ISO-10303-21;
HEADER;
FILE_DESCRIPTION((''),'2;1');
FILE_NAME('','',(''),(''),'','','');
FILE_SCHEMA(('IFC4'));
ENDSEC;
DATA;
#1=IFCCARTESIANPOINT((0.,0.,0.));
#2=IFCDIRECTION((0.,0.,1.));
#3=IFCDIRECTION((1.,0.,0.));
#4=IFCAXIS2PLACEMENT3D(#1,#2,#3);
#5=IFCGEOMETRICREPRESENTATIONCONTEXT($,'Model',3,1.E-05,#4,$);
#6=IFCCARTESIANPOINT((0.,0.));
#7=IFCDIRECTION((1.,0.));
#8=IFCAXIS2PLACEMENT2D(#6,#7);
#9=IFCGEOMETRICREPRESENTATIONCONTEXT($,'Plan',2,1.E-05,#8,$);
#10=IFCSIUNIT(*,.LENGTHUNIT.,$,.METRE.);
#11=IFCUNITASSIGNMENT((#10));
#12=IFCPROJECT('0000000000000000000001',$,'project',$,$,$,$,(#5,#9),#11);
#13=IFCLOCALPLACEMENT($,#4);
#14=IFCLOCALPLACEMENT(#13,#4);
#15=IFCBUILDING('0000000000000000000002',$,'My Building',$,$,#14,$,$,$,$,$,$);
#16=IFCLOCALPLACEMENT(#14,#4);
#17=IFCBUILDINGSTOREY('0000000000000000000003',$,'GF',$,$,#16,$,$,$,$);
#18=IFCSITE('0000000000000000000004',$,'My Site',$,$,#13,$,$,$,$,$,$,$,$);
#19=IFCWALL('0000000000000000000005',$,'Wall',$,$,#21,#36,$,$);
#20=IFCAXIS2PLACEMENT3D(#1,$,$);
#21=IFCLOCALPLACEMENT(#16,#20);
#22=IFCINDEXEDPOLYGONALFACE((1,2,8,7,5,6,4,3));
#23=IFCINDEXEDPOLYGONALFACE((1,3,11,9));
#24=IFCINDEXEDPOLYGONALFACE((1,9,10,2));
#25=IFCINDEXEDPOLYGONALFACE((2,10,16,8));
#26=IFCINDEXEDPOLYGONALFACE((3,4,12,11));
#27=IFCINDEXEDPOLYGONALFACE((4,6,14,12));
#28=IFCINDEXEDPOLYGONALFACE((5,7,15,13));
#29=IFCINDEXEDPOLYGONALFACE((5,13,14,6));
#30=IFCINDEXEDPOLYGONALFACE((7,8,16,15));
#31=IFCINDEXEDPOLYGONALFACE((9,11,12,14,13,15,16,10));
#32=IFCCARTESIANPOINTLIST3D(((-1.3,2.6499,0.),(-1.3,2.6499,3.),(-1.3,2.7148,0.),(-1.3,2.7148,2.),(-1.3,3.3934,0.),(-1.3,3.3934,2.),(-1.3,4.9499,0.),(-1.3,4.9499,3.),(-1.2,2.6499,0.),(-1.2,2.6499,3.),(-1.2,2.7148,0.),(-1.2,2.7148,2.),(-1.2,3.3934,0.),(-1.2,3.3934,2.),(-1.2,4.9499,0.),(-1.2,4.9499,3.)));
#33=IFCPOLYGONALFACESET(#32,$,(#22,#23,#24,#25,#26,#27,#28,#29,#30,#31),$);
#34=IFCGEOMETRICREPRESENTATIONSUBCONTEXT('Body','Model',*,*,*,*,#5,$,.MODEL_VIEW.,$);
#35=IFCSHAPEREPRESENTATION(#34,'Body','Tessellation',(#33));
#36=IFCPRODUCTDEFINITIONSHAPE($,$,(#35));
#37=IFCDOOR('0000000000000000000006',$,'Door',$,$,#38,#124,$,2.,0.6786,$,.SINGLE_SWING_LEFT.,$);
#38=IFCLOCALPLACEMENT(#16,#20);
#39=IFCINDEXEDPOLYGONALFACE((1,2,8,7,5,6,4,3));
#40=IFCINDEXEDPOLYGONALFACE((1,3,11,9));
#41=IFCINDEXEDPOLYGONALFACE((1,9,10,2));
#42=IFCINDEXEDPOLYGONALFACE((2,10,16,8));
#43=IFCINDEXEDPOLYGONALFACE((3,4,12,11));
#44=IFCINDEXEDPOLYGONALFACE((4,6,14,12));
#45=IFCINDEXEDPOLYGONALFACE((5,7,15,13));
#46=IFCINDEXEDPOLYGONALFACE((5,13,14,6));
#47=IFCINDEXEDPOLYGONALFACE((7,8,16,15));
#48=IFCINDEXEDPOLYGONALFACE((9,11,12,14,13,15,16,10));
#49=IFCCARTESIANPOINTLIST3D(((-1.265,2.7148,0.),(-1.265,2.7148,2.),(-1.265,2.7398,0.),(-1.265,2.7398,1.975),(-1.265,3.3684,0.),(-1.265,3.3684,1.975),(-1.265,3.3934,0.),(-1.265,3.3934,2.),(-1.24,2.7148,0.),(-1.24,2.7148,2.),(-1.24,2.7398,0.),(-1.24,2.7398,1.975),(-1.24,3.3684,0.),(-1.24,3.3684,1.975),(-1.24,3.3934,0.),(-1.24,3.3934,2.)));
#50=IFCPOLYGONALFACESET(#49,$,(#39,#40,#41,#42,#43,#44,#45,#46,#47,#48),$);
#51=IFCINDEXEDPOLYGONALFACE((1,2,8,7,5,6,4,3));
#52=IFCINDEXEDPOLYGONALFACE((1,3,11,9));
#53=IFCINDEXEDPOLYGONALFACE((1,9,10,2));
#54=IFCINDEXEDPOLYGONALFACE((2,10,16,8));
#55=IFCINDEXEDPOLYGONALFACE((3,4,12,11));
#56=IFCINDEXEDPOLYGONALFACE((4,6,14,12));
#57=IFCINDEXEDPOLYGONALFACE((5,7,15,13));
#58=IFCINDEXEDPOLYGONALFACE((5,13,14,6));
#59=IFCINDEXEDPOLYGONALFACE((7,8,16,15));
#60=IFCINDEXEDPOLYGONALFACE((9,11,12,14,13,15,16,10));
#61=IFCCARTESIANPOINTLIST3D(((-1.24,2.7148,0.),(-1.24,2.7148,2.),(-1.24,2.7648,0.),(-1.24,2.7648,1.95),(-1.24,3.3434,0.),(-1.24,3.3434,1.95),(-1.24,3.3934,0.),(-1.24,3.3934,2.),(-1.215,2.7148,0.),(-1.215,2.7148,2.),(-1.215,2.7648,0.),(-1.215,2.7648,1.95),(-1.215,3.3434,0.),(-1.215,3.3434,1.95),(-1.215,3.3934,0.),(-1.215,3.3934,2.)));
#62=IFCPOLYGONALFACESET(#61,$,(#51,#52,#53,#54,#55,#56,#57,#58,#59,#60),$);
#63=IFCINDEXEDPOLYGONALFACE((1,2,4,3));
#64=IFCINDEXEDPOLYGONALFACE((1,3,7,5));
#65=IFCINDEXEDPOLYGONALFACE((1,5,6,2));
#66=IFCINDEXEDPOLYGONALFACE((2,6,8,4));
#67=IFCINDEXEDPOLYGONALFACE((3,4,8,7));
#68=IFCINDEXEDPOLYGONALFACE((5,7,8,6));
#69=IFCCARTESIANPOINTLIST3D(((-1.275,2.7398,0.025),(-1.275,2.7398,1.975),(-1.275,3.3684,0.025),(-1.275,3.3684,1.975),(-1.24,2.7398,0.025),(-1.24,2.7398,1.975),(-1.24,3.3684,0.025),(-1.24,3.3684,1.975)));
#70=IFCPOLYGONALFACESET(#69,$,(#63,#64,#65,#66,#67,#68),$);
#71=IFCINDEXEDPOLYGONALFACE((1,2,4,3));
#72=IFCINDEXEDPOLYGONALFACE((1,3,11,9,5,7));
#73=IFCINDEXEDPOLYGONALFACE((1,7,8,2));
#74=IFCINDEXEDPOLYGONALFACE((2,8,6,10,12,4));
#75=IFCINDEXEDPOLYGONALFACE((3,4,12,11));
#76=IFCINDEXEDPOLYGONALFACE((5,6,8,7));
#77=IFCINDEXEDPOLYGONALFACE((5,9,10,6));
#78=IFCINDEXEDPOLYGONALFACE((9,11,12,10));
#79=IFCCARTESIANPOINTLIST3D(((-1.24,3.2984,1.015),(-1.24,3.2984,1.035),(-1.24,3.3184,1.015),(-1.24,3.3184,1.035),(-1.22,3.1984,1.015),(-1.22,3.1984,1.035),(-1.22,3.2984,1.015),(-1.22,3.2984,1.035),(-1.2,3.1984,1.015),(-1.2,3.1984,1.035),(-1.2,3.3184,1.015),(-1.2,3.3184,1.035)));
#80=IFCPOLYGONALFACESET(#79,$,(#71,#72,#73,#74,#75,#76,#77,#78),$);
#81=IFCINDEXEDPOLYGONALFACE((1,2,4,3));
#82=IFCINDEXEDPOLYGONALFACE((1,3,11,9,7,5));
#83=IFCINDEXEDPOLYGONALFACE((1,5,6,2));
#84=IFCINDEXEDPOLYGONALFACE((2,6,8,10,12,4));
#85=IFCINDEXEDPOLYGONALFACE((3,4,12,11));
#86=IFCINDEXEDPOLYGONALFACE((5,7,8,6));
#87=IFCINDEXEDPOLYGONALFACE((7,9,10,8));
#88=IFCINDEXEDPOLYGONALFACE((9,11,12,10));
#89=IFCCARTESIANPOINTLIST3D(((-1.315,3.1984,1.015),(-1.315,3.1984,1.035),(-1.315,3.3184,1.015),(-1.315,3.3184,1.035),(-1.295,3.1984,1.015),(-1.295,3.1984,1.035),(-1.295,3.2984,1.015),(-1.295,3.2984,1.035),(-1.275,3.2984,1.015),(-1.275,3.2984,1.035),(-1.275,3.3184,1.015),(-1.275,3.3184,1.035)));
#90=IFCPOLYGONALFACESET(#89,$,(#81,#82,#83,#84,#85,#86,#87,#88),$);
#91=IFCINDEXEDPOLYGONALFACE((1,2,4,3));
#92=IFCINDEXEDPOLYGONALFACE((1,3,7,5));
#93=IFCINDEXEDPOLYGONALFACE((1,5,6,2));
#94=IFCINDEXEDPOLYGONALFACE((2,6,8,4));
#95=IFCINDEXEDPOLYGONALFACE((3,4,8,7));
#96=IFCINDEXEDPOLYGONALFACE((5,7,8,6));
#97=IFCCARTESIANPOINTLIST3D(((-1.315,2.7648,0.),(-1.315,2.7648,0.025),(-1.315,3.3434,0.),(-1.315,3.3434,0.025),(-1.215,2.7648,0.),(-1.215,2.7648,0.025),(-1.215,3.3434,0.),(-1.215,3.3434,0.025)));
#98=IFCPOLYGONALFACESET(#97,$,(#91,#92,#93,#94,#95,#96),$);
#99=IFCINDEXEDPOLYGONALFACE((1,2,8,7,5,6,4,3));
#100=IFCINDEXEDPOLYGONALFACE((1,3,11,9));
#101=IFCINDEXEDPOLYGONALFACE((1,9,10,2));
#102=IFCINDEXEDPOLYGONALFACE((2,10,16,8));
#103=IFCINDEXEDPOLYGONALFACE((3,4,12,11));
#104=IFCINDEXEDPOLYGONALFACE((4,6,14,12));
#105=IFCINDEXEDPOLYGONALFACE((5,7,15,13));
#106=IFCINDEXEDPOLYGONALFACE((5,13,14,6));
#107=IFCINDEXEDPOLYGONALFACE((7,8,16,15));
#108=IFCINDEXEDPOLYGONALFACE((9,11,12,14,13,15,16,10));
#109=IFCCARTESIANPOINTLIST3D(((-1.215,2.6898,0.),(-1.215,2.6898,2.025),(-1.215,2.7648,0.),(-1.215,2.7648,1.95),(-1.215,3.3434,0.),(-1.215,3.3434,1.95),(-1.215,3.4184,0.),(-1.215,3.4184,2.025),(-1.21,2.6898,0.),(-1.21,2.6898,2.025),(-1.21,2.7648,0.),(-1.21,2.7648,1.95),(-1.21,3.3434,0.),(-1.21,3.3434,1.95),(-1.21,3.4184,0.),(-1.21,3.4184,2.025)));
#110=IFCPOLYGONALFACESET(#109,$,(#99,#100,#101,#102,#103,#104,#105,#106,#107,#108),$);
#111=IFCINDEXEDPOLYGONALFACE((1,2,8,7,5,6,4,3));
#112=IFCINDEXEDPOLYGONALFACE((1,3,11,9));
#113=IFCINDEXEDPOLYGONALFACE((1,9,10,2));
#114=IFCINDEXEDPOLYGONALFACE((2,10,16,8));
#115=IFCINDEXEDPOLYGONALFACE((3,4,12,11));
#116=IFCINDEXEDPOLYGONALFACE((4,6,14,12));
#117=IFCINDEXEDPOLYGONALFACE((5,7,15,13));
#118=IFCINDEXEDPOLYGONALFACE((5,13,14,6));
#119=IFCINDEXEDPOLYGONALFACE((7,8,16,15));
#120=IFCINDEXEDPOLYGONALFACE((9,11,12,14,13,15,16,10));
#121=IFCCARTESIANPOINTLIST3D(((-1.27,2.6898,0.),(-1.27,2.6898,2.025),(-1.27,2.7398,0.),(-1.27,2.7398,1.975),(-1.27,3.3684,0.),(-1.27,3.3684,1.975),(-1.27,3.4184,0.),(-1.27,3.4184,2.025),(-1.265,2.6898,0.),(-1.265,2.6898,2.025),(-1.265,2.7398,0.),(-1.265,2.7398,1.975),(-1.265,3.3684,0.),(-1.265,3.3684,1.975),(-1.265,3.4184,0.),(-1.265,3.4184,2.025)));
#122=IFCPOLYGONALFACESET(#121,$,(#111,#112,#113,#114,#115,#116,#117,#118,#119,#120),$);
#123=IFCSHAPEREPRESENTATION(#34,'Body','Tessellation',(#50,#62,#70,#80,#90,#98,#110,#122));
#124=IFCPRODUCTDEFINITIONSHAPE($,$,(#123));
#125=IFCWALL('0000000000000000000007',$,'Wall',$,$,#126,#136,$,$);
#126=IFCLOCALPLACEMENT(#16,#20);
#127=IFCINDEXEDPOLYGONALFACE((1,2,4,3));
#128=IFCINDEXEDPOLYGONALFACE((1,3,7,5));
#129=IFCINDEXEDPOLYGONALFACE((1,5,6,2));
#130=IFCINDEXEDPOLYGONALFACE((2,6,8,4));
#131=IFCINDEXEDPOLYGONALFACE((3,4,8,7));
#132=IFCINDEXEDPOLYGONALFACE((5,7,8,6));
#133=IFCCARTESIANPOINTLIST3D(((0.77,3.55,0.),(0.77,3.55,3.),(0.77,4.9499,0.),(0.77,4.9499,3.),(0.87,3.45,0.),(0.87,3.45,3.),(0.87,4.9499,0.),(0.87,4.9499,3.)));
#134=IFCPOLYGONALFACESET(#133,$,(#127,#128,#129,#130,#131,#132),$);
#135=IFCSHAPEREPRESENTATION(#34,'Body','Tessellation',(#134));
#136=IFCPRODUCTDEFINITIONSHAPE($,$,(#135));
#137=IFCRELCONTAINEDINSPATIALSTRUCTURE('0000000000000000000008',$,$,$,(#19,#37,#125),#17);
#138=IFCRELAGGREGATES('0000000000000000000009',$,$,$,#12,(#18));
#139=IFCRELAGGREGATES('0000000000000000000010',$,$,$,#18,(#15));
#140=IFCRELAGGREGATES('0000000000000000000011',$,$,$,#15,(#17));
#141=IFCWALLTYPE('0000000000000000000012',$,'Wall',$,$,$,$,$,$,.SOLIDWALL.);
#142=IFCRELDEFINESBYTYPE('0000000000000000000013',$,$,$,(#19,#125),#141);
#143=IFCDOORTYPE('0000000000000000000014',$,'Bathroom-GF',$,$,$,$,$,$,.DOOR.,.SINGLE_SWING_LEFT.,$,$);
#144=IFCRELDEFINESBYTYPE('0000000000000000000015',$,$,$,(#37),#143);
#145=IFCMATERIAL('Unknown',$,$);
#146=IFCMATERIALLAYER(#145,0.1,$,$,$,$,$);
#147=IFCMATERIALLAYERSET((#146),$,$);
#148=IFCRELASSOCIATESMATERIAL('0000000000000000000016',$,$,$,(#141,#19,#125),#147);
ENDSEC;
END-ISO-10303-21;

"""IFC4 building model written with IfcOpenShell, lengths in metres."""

from ifc_helpers import new_model, entity, si_unit, frame, origin_with_axes, origin_2d_with_axis, place, context, subcontext, project, spatial, line, indexed_curve, outline, extrude, shape, source, transform, mapped, material, layer, layer_set, layer_usage, type_object, type_shapes, element, fill, save


model = new_model("IFC4")

# Units and contexts
model_context = context("Model", 3, precision=1e-05, world=origin_with_axes())
plan_context = context("Plan", 2, precision=1e-05, world=origin_2d_with_axis())
body_context_1 = subcontext(model_context, "Body", "Model", "MODEL_VIEW")
body_context_2 = subcontext(plan_context, "Body", "Plan", "PLAN_VIEW")
ifc_project = project(units=[si_unit("LENGTHUNIT", "METRE")], contexts=[model_context, plan_context])

# Site, building, storey
site_placement = place(None, origin_with_axes())
site = spatial("IfcSite", under=ifc_project, at=site_placement, Name="My Site")
building_placement = place(site_placement, origin_with_axes())
building = spatial("IfcBuilding", under=site, at=building_placement, Name="My Building")
storey_placement = place(building_placement, origin_with_axes())
storey = spatial("IfcBuildingStorey", under=building, at=storey_placement, Name="GF")

# Shared definitions
ifc_material = material(Name="Unknown")

# Shared definitions
ifc_layer_1 = layer(ifc_material, 0.1)
ifc_layer_set_1 = layer_set([ifc_layer_1])
wall_type = type_object("IfcWallType", Name="Wall", PredefinedType="SOLIDWALL", material=ifc_layer_set_1)

# Wall, opening, door
ifc_layer_usage_1 = layer_usage(ifc_layer_set_1, "AXIS2", "POSITIVE", 0.0)
wall_1_placement = place(storey_placement, frame((-1.2, 2.6499, 0.0), z_axis=(0.0, 0.0, 1.0), x_axis=(0.0, 1.0, 0.0)))
wall_1 = element("IfcWall", 1, at=wall_1_placement, inside=storey, type_object=wall_type, material=ifc_layer_usage_1, Name="Wall", context=body_context_1, shape_type="SweptSolid", body=[
    extrude(outline(indexed_curve([(0.0, 0.0), (0.0, 0.1), (2.3, 0.1), (2.3, 0.0)], segments=[line(1, 2, 3, 4, 1)])), origin_with_axes(), (0.0, 0.0, 1.0), 3.0),
])
shared_shape_1 = source(origin_with_axes(), body_context_1, "Body", "SweptSolid", [
    extrude(outline(indexed_curve([(0.0, 0.0), (0.6786, 0.0), (0.6786, 2.0), (0.0, 2.0)], segments=[line(1, 2, 3, 4, 1)])), frame((0.0, -0.6, 0.0), z_axis=(0.0, -1.0, 0.0), x_axis=(1.0, 0.0, 0.0)), (0.0, 0.0, -1.0), 1.2),
])
opening_1_placement = place(wall_1_placement, frame((0.0649, 0.015, 0.0), z_axis=(0.0, 0.0, 1.0), x_axis=(1.0, 0.0, 0.0)))
opening_1 = element("IfcOpeningElement", 2, at=opening_1_placement, cuts=wall_1, PredefinedType="OPENING", context=body_context_1, shape_type="MappedRepresentation", body=[
    mapped(shared_shape_1, transform((0.0, 0.0, 0.0), x_axis=(1.0, 0.0, 0.0), y_axis=(0.0, 1.0, 0.0), z_axis=(0.0, 0.0, 1.0), scale=1.0)),
])
door_type_1 = type_object("IfcDoorType", Name="Bathroom-GF", OperationType="SINGLE_SWING_LEFT", PredefinedType="DOOR")
shared_shape_2 = source(origin_with_axes(), body_context_1, "Body", "SweptSolid", [
    extrude(outline(indexed_curve([(0.0, 0.0), (0.0, 2.0), (0.6786, 2.0), (0.6786, 0.0), (0.6536, 0.0), (0.6536, 1.975), (0.025, 1.975), (0.025, 0.0)], segments=[line(1, 2, 3, 4, 5, 6, 7, 8, 1)])), frame((0.0, 0.025, 0.0), z_axis=(0.0, -1.0, 0.0), x_axis=(1.0, 0.0, 0.0)), (0.0, 0.0, -1.0), 0.025),
    extrude(outline(indexed_curve([(0.0, 0.0), (0.0, 2.0), (0.6786, 2.0), (0.6786, 0.0), (0.6286, 0.0), (0.6286, 1.95), (0.05, 1.95), (0.05, 0.0)], segments=[line(1, 2, 3, 4, 5, 6, 7, 8, 1)])), frame((0.0, 0.0, 0.0), z_axis=(0.0, -1.0, 0.0), x_axis=(1.0, 0.0, 0.0)), (0.0, 0.0, -1.0), 0.025),
    extrude(outline(indexed_curve([(0.0, 0.0), (0.6286, 0.0), (0.6286, 0.035), (0.0, 0.035)], segments=[line(1, 2, 3, 4, 1)])), frame((0.025, 0.025, 0.025), z_axis=(0.0, 0.0, 1.0), x_axis=(1.0, 0.0, 0.0)), (0.0, 0.0, 1.0), 1.95),
    extrude(outline(indexed_curve([(0.0, 0.0), (0.0, -0.04), (-0.12, -0.04), (-0.12, -0.02), (-0.02, -0.02), (-0.02, 0.0)], segments=[line(1, 2, 3, 4, 5, 6, 1)])), frame((0.6036, 0.025, 1.015), z_axis=(0.0, 0.0, 1.0), x_axis=(1.0, 0.0, 0.0)), (0.0, 0.0, 1.0), 0.02),
    extrude(outline(indexed_curve([(0.0, 0.0), (0.0, 0.04), (-0.12, 0.04), (-0.12, 0.02), (-0.02, 0.02), (-0.02, 0.0)], segments=[line(1, 2, 3, 4, 5, 6, 1)])), frame((0.6036, 0.06, 1.015), z_axis=(0.0, 0.0, 1.0), x_axis=(1.0, 0.0, 0.0)), (0.0, 0.0, 1.0), 0.02),
    extrude(outline(indexed_curve([(0.0, 0.0), (0.5786, 0.0), (0.5786, 0.1), (0.0, 0.1)], segments=[line(1, 2, 3, 4, 1)])), frame((0.05, 0.0, 0.0), z_axis=(0.0, 0.0, 1.0), x_axis=(1.0, 0.0, 0.0)), (0.0, 0.0, 1.0), 0.025),
    extrude(outline(indexed_curve([(0.0, 0.0), (0.0, 2.025), (0.7286, 2.025), (0.7286, 0.0), (0.6536, 0.0), (0.6536, 1.95), (0.075, 1.95), (0.075, 0.0)], segments=[line(1, 2, 3, 4, 5, 6, 7, 8, 1)])), frame((-0.025, -0.005, 0.0), z_axis=(0.0, -1.0, 0.0), x_axis=(1.0, 0.0, 0.0)), (0.0, 0.0, -1.0), 0.005),
    extrude(outline(indexed_curve([(0.0, 0.0), (0.0, 2.025), (0.7286, 2.025), (0.7286, 0.0), (0.6786, 0.0), (0.6786, 1.975), (0.05, 1.975), (0.05, 0.0)], segments=[line(1, 2, 3, 4, 5, 6, 7, 8, 1)])), frame((-0.025, 0.05, 0.0), z_axis=(0.0, -1.0, 0.0), x_axis=(1.0, 0.0, 0.0)), (0.0, 0.0, -1.0), 0.005),
])
shared_shape_3 = source(origin_with_axes(), body_context_2, "Body", "Curve2D", [
    entity("IfcIndexedPolyCurve", entity("IfcCartesianPointList2D", [[0.0, 0.0], [0.0, 0.05], [0.025, 0.05], [0.025, 0.025], [0.05, 0.025], [0.05, 0.0]]), [entity("IfcLineIndex", [1, 2, 3, 4, 5, 6, 1])]),
    entity("IfcIndexedPolyCurve", entity("IfcCartesianPointList2D", [[0.6786, 0.0], [0.6786, 0.05], [0.6536, 0.05], [0.6536, 0.025], [0.6286, 0.025], [0.6286, 0.0]]), [entity("IfcLineIndex", [1, 2, 3, 4, 5, 6, 1])]),
    entity("IfcTrimmedCurve", entity("IfcEllipse", entity("IfcAxis2Placement2D", entity("IfcCartesianPoint", [0.06, 0.05]), entity("IfcDirection", [1.0, 0.0])), 0.5936, 0.6286), [entity("IfcCartesianPoint", [0.6536, 0.05])], [entity("IfcCartesianPoint", [0.06, 0.6786])], True, "CARTESIAN"),
    entity("IfcIndexedPolyCurve", entity("IfcCartesianPointList2D", [[0.025, 0.05], [0.06, 0.05], [0.06, 0.6786], [0.025, 0.6786]]), [entity("IfcLineIndex", [1, 2, 3, 4, 1])]),
])
type_shapes(door_type_1, [shared_shape_2, shared_shape_3])
door_1_placement = place(opening_1_placement, origin_with_axes())
door_1 = element("IfcDoor", 3, at=door_1_placement, inside=storey, type_object=door_type_1, Name="Door", OperationType="SINGLE_SWING_LEFT", OverallHeight=2.0, OverallWidth=0.6786, shapes=[
    shape(body_context_1, "Body", "MappedRepresentation", [mapped(shared_shape_2, transform((0.0, 0.0, 0.0), x_axis=(1.0, 0.0, 0.0), y_axis=(0.0, 1.0, 0.0), z_axis=(0.0, 0.0, 1.0), scale=1.0))]),
    shape(body_context_2, "Body", "MappedRepresentation", [mapped(shared_shape_3, transform((0.0, 0.0, 0.0), x_axis=(1.0, 0.0, 0.0), y_axis=(0.0, 1.0, 0.0), z_axis=(0.0, 0.0, 1.0), scale=1.0))]),
])
fill(opening_1, door_1)

# Wall
ifc_layer_usage_2 = layer_usage(ifc_layer_set_1, "AXIS2", "POSITIVE", 0.0)
wall_2_placement = place(storey_placement, frame((0.77, 5.0499, 0.0), z_axis=(0.0, 0.0, 1.0), x_axis=(0.0, -1.0, 0.0)))
element("IfcWall", 4, at=wall_2_placement, inside=storey, type_object=wall_type, material=ifc_layer_usage_2, Name="Wall", context=body_context_1, shape_type="SweptSolid", body=[
    extrude(outline(indexed_curve([(0.1, 0.0), (0.1, 0.1), (1.5999, 0.1), (1.4999, 0.0)], segments=[line(1, 2, 3, 4, 1)])), origin_with_axes(), (0.0, 0.0, 1.0), 3.0),
])

save(model, "model.ifc")
